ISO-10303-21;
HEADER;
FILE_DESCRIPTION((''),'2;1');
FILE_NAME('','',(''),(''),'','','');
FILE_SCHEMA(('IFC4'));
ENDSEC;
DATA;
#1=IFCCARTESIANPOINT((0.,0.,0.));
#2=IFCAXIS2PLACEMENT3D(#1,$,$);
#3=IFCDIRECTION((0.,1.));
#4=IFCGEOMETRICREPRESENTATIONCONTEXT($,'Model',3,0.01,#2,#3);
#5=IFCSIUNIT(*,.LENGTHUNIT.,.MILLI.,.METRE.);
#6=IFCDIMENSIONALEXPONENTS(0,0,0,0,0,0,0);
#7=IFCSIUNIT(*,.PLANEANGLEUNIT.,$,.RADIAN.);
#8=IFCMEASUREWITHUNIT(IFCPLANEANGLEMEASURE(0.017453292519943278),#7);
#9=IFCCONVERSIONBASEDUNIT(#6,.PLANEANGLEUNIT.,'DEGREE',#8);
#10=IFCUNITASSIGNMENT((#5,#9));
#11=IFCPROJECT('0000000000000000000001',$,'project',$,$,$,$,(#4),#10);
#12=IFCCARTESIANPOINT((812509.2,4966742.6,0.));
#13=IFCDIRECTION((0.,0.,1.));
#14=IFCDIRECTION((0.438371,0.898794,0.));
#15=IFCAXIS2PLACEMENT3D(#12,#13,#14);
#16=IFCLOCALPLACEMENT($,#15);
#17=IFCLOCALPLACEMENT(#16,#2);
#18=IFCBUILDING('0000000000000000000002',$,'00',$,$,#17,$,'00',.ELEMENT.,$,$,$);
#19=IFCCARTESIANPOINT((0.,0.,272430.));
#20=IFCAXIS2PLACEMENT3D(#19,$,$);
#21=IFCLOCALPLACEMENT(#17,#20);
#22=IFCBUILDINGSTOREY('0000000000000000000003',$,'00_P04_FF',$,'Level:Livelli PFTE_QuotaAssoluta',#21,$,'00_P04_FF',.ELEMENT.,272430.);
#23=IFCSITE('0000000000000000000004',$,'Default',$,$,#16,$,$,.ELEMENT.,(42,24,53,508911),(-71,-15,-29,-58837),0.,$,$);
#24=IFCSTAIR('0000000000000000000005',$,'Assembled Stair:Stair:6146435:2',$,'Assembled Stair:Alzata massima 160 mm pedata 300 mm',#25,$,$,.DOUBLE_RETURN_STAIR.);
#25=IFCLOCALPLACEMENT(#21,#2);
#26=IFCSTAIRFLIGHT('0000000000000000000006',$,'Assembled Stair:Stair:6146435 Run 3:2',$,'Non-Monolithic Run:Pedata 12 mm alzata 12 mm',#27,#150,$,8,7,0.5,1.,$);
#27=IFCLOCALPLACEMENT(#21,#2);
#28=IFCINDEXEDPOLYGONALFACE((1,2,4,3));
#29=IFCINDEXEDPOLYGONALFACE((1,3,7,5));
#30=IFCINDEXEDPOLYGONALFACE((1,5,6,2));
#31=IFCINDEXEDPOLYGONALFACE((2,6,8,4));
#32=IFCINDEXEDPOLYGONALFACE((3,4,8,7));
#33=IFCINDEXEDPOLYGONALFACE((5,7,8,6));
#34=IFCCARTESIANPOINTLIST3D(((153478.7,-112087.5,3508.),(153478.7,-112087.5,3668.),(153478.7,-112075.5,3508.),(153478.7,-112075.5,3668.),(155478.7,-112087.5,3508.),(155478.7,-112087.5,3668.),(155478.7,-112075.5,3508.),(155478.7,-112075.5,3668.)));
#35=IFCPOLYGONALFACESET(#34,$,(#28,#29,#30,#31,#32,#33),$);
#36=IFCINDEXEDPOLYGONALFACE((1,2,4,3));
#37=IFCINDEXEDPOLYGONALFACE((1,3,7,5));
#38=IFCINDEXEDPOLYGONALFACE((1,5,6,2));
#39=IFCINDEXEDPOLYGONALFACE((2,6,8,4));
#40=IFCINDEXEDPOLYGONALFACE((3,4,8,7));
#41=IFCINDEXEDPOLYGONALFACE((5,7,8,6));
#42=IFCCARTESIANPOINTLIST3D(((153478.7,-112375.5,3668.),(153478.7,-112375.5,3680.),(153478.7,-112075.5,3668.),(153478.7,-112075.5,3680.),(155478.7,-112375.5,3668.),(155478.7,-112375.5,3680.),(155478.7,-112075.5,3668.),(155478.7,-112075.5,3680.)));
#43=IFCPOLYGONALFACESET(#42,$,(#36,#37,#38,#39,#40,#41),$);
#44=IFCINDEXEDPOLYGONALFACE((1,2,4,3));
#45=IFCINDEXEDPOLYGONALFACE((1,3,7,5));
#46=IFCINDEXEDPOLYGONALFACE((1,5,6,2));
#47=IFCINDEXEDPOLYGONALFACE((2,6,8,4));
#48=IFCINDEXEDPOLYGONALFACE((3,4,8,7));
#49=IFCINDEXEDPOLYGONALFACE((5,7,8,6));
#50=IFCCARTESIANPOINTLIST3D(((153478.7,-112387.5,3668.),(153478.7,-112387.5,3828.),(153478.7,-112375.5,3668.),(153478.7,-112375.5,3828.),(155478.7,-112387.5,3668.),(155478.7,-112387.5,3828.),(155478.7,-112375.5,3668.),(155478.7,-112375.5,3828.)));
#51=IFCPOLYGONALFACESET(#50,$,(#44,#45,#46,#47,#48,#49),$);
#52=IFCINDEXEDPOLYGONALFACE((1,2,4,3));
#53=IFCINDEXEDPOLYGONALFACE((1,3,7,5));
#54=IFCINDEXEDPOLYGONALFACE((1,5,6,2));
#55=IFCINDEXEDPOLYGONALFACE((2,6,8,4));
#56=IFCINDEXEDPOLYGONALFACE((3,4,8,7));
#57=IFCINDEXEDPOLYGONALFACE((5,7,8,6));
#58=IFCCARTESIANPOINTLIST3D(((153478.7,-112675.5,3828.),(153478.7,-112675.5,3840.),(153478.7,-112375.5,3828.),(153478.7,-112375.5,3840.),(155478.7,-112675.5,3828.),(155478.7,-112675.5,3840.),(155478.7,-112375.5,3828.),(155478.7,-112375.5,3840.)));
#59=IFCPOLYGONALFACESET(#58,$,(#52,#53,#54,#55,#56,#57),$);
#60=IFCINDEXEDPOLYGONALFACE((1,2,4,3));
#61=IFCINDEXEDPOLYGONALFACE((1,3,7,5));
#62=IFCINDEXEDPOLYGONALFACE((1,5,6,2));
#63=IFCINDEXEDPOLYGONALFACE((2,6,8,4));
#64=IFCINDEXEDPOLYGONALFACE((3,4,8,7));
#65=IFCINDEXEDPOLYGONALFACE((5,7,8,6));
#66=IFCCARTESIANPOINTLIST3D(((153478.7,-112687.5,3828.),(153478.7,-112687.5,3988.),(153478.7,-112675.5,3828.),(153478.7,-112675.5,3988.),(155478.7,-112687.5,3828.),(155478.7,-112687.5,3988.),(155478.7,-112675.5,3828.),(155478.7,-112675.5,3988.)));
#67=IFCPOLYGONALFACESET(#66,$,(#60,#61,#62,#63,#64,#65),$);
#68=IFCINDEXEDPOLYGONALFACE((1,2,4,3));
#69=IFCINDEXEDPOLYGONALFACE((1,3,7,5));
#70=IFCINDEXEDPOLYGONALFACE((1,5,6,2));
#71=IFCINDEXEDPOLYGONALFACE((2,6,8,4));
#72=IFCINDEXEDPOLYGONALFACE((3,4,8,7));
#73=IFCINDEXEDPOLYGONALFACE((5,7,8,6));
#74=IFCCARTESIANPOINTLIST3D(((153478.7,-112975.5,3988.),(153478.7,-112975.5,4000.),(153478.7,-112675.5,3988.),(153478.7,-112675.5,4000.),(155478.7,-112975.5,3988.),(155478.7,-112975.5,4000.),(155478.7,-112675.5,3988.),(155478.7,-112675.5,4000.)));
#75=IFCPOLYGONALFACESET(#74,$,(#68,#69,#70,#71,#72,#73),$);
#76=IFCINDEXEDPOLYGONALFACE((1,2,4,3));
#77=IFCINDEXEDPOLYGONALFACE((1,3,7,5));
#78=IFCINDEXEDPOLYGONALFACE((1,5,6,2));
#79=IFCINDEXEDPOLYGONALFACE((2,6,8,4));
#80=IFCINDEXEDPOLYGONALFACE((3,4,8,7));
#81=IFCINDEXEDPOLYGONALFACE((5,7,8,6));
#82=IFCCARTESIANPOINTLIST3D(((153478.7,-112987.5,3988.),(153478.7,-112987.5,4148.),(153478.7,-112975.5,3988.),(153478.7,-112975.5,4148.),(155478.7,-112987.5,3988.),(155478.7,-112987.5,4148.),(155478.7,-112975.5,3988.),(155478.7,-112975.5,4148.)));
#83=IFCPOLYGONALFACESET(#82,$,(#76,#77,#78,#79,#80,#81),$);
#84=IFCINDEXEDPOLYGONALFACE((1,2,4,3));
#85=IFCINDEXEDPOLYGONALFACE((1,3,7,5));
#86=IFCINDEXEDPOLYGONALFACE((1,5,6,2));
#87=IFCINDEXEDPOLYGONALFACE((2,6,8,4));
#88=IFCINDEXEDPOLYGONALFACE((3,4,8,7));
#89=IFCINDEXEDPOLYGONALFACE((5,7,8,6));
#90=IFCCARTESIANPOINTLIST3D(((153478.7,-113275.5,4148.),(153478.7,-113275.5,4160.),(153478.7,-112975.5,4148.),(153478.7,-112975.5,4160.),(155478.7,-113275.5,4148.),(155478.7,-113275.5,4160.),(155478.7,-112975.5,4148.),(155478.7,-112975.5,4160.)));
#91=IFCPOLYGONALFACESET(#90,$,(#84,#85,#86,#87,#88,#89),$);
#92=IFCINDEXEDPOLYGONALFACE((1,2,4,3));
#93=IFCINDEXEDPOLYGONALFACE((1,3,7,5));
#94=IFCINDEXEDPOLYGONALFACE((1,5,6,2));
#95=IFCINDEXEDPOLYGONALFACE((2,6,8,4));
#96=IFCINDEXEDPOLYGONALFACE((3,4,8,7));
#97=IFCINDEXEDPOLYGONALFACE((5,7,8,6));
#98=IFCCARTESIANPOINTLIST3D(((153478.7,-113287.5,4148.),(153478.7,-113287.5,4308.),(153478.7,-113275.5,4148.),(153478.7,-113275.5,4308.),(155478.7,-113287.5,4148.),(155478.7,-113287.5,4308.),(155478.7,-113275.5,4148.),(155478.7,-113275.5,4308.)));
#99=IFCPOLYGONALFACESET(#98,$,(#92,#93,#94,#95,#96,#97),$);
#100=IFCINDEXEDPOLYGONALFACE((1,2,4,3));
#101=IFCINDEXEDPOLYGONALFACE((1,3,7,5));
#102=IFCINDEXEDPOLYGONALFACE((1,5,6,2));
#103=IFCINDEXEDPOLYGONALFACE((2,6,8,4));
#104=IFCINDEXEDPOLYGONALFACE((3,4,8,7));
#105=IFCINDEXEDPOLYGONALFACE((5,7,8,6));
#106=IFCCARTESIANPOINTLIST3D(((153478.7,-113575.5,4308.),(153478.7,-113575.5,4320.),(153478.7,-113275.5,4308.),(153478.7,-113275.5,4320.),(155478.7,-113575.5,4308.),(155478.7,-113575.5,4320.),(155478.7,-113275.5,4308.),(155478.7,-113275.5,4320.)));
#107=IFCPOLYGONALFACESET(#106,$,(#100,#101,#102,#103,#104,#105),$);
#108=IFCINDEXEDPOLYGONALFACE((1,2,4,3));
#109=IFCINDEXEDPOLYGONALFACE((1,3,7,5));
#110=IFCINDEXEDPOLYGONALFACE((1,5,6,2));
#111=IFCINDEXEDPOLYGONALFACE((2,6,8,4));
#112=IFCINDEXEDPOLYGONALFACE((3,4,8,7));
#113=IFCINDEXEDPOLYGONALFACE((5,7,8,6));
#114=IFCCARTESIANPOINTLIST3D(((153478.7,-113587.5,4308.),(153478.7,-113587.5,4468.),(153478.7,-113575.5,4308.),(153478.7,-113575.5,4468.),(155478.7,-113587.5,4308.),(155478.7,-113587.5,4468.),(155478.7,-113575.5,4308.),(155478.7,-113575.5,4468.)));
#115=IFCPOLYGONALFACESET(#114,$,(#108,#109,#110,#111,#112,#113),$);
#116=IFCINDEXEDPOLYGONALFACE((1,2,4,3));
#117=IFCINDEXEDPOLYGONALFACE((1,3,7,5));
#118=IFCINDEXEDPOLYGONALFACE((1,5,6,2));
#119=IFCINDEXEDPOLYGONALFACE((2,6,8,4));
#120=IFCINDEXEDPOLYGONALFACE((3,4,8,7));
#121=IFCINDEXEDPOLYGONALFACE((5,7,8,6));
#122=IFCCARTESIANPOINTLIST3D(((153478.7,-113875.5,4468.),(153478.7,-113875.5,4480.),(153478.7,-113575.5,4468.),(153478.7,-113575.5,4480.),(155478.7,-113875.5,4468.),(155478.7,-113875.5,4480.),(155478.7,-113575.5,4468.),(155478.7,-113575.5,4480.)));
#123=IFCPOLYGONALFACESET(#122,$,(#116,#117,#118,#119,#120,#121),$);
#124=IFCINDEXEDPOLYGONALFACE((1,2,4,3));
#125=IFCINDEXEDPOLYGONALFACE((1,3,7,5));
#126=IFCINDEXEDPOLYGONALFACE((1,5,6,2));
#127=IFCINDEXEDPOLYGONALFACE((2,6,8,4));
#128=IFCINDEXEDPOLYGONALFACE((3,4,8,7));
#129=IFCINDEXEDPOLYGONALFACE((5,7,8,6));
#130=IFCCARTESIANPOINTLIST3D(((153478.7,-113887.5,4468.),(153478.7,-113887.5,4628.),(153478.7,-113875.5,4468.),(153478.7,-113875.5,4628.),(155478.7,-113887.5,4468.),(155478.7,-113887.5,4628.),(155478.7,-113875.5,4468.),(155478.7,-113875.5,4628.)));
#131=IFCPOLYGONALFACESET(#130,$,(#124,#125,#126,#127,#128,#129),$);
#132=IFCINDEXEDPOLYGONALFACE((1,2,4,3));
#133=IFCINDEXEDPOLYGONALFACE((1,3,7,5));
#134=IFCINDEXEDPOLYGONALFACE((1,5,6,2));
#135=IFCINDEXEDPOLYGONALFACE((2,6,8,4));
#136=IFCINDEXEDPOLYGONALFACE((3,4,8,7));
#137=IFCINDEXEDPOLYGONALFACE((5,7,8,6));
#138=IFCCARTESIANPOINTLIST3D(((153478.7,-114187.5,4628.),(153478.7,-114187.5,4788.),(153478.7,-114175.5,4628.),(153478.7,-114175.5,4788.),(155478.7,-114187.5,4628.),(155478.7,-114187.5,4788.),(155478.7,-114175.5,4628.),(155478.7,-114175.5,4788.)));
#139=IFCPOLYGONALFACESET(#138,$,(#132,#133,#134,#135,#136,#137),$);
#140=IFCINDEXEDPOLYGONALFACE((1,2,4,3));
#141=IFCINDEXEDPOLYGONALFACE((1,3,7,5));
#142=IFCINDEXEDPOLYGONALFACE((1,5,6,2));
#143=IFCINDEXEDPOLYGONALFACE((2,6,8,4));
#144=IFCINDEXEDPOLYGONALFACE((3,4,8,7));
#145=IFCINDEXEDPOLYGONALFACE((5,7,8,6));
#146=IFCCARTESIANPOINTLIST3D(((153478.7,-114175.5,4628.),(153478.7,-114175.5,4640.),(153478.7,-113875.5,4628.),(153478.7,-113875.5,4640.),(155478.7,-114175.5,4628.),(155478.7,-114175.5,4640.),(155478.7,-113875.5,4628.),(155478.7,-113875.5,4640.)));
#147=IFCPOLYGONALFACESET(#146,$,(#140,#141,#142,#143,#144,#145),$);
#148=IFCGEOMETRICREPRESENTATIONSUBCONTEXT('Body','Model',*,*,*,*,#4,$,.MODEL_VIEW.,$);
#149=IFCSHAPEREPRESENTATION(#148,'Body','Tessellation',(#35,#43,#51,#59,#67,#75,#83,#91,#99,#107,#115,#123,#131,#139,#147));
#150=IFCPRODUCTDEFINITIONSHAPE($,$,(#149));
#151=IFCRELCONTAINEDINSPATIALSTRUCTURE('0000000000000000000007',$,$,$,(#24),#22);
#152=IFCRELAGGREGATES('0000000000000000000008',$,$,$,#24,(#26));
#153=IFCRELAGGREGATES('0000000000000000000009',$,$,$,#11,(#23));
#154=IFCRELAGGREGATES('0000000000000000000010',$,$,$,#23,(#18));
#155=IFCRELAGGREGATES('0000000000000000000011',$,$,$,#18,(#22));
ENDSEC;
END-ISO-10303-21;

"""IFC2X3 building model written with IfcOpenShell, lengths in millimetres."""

from ifc_helpers import new_model, entity, si_unit, converted_unit, direction, frame, frame_2d, origin, origin_2d_with_axis, place, context, subcontext, project, spatial, rectangle, extrude, element, aggregate, save


model = new_model("IFC2X3")

# Units and contexts
model_context = context("Model", 3, precision=0.01, world=origin(), true_north=direction((0.0, 1.0)))
body_context = subcontext(model_context, "Body", "Model", "MODEL_VIEW")
ifc_project = project(units=[si_unit("LENGTHUNIT", "METRE", prefix="MILLI"), converted_unit("PLANEANGLEUNIT", "DEGREE", entity("IfcPlaneAngleMeasure", 0.017453292519943278), si_unit("PLANEANGLEUNIT", "RADIAN"), dimensions=[0, 0, 0, 0, 0, 0, 0])], contexts=[model_context])

# Site, building, storey
site_placement = place(None, frame((812509.2, 4966742.6, 0.0), z_axis=(0.0, 0.0, 1.0), x_axis=(0.438371, 0.898794, 0.0)))
site = spatial("IfcSite", under=ifc_project, at=site_placement, Name="Default", CompositionType="ELEMENT", RefLatitude=(42, 24, 53, 508911), RefLongitude=(-71, -15, -29, -58837), RefElevation=0.0)
building_placement = place(site_placement, origin())
building = spatial("IfcBuilding", under=site, at=building_placement, Name="00", LongName="00", CompositionType="ELEMENT")
storey_placement = place(building_placement, frame((0.0, 0.0, 272430.0)))
storey = spatial("IfcBuildingStorey", under=building, at=storey_placement, Name="00_P04_FF", ObjectType="Level:Livelli PFTE_QuotaAssoluta", LongName="00_P04_FF", CompositionType="ELEMENT", Elevation=272430.0)

# Stair
stair_1_placement = place(storey_placement, origin())
stair_1 = element("IfcStair", 1, at=stair_1_placement, inside=storey, Name="Assembled Stair:Stair:6146435:2", ObjectType="Assembled Stair:Alzata massima 160 mm pedata 300 mm", ShapeType="DOUBLE_RETURN_STAIR")

# Stair flight
stair_flight_1_placement = place(stair_1_placement, origin())
stair_flight_1 = element("IfcStairFlight", 2, at=stair_flight_1_placement, Name="Assembled Stair:Stair:6146435 Run 3:2", ObjectType="Non-Monolithic Run:Pedata 12 mm alzata 12 mm", NumberOfRiser=8, NumberOfTreads=7, RiserHeight=0.5, TreadLength=1.0, context=body_context, shape_type="SweptSolid", body=[
    extrude(rectangle(XDim=2000.0, YDim=12.0, at=origin_2d_with_axis()), frame((154478.7, -112081.5, 3508.0)), (0.0, 0.0, 1.0), 160.0),
    extrude(rectangle(XDim=300.0, YDim=2000.0, at=origin_2d_with_axis()), frame((154478.7, -112225.5, 3668.0), z_axis=(0.0, 0.0, 1.0), x_axis=(0.0, 1.0, 0.0)), (0.0, 0.0, 1.0), 12.0),
    extrude(rectangle(XDim=2000.0, YDim=12.0, at=origin_2d_with_axis()), frame((154478.7, -112381.5, 3668.0)), (0.0, 0.0, 1.0), 160.0),
    extrude(rectangle(XDim=300.0, YDim=2000.0, at=origin_2d_with_axis()), frame((154478.7, -112525.5, 3828.0), z_axis=(0.0, 0.0, 1.0), x_axis=(0.0, 1.0, 0.0)), (0.0, 0.0, 1.0), 12.0),
    extrude(rectangle(XDim=2000.0, YDim=12.0, at=origin_2d_with_axis()), frame((154478.7, -112681.5, 3828.0)), (0.0, 0.0, 1.0), 160.0),
    extrude(rectangle(XDim=300.0, YDim=2000.0, at=origin_2d_with_axis()), frame((154478.7, -112825.5, 3988.0), z_axis=(0.0, 0.0, 1.0), x_axis=(0.0, 1.0, 0.0)), (0.0, 0.0, 1.0), 12.0),
    extrude(rectangle(XDim=2000.0, YDim=12.0, at=frame_2d((0.0, 0.0), x_axis=(1.0, 0.0))), frame((154478.7, -112981.5, 3988.0)), (0.0, 0.0, 1.0), 160.0),
    extrude(rectangle(XDim=300.0, YDim=2000.0, at=frame_2d((0.0, 0.0), x_axis=(1.0, 0.0))), frame((154478.7, -113125.5, 4148.0), z_axis=(0.0, 0.0, 1.0), x_axis=(0.0, 1.0, 0.0)), (0.0, 0.0, 1.0), 12.0),
    extrude(rectangle(XDim=2000.0, YDim=12.0, at=frame_2d((0.0, 0.0), x_axis=(1.0, 0.0))), frame((154478.7, -113281.5, 4148.0)), (0.0, 0.0, 1.0), 160.0),
    extrude(rectangle(XDim=300.0, YDim=2000.0, at=frame_2d((0.0, 0.0), x_axis=(1.0, 0.0))), frame((154478.7, -113425.5, 4308.0), z_axis=(0.0, 0.0, 1.0), x_axis=(0.0, 1.0, 0.0)), (0.0, 0.0, 1.0), 12.0),
    extrude(rectangle(XDim=2000.0, YDim=12.0, at=frame_2d((0.0, 0.0), x_axis=(1.0, 0.0))), frame((154478.7, -113581.5, 4308.0)), (0.0, 0.0, 1.0), 160.0),
    extrude(rectangle(XDim=300.0, YDim=2000.0, at=frame_2d((0.0, 0.0), x_axis=(1.0, 0.0))), frame((154478.7, -113725.5, 4468.0), z_axis=(0.0, 0.0, 1.0), x_axis=(0.0, 1.0, 0.0)), (0.0, 0.0, 1.0), 12.0),
    extrude(rectangle(XDim=2000.0, YDim=12.0, at=frame_2d((0.0, 0.0), x_axis=(1.0, 0.0))), frame((154478.7, -113881.5, 4468.0)), (0.0, 0.0, 1.0), 160.0),
    extrude(rectangle(XDim=2000.0, YDim=12.0, at=frame_2d((0.0, 0.0), x_axis=(1.0, 0.0))), frame((154478.7, -114181.5, 4628.0)), (0.0, 0.0, 1.0), 160.0),
    extrude(rectangle(XDim=300.0, YDim=2000.0, at=frame_2d((0.0, 0.0), x_axis=(1.0, 0.0))), frame((154478.7, -114025.5, 4628.0), z_axis=(0.0, 0.0, 1.0), x_axis=(0.0, 1.0, 0.0)), (0.0, 0.0, 1.0), 12.0),
])
aggregate(stair_1, [stair_flight_1])

save(model, "model.ifc")
